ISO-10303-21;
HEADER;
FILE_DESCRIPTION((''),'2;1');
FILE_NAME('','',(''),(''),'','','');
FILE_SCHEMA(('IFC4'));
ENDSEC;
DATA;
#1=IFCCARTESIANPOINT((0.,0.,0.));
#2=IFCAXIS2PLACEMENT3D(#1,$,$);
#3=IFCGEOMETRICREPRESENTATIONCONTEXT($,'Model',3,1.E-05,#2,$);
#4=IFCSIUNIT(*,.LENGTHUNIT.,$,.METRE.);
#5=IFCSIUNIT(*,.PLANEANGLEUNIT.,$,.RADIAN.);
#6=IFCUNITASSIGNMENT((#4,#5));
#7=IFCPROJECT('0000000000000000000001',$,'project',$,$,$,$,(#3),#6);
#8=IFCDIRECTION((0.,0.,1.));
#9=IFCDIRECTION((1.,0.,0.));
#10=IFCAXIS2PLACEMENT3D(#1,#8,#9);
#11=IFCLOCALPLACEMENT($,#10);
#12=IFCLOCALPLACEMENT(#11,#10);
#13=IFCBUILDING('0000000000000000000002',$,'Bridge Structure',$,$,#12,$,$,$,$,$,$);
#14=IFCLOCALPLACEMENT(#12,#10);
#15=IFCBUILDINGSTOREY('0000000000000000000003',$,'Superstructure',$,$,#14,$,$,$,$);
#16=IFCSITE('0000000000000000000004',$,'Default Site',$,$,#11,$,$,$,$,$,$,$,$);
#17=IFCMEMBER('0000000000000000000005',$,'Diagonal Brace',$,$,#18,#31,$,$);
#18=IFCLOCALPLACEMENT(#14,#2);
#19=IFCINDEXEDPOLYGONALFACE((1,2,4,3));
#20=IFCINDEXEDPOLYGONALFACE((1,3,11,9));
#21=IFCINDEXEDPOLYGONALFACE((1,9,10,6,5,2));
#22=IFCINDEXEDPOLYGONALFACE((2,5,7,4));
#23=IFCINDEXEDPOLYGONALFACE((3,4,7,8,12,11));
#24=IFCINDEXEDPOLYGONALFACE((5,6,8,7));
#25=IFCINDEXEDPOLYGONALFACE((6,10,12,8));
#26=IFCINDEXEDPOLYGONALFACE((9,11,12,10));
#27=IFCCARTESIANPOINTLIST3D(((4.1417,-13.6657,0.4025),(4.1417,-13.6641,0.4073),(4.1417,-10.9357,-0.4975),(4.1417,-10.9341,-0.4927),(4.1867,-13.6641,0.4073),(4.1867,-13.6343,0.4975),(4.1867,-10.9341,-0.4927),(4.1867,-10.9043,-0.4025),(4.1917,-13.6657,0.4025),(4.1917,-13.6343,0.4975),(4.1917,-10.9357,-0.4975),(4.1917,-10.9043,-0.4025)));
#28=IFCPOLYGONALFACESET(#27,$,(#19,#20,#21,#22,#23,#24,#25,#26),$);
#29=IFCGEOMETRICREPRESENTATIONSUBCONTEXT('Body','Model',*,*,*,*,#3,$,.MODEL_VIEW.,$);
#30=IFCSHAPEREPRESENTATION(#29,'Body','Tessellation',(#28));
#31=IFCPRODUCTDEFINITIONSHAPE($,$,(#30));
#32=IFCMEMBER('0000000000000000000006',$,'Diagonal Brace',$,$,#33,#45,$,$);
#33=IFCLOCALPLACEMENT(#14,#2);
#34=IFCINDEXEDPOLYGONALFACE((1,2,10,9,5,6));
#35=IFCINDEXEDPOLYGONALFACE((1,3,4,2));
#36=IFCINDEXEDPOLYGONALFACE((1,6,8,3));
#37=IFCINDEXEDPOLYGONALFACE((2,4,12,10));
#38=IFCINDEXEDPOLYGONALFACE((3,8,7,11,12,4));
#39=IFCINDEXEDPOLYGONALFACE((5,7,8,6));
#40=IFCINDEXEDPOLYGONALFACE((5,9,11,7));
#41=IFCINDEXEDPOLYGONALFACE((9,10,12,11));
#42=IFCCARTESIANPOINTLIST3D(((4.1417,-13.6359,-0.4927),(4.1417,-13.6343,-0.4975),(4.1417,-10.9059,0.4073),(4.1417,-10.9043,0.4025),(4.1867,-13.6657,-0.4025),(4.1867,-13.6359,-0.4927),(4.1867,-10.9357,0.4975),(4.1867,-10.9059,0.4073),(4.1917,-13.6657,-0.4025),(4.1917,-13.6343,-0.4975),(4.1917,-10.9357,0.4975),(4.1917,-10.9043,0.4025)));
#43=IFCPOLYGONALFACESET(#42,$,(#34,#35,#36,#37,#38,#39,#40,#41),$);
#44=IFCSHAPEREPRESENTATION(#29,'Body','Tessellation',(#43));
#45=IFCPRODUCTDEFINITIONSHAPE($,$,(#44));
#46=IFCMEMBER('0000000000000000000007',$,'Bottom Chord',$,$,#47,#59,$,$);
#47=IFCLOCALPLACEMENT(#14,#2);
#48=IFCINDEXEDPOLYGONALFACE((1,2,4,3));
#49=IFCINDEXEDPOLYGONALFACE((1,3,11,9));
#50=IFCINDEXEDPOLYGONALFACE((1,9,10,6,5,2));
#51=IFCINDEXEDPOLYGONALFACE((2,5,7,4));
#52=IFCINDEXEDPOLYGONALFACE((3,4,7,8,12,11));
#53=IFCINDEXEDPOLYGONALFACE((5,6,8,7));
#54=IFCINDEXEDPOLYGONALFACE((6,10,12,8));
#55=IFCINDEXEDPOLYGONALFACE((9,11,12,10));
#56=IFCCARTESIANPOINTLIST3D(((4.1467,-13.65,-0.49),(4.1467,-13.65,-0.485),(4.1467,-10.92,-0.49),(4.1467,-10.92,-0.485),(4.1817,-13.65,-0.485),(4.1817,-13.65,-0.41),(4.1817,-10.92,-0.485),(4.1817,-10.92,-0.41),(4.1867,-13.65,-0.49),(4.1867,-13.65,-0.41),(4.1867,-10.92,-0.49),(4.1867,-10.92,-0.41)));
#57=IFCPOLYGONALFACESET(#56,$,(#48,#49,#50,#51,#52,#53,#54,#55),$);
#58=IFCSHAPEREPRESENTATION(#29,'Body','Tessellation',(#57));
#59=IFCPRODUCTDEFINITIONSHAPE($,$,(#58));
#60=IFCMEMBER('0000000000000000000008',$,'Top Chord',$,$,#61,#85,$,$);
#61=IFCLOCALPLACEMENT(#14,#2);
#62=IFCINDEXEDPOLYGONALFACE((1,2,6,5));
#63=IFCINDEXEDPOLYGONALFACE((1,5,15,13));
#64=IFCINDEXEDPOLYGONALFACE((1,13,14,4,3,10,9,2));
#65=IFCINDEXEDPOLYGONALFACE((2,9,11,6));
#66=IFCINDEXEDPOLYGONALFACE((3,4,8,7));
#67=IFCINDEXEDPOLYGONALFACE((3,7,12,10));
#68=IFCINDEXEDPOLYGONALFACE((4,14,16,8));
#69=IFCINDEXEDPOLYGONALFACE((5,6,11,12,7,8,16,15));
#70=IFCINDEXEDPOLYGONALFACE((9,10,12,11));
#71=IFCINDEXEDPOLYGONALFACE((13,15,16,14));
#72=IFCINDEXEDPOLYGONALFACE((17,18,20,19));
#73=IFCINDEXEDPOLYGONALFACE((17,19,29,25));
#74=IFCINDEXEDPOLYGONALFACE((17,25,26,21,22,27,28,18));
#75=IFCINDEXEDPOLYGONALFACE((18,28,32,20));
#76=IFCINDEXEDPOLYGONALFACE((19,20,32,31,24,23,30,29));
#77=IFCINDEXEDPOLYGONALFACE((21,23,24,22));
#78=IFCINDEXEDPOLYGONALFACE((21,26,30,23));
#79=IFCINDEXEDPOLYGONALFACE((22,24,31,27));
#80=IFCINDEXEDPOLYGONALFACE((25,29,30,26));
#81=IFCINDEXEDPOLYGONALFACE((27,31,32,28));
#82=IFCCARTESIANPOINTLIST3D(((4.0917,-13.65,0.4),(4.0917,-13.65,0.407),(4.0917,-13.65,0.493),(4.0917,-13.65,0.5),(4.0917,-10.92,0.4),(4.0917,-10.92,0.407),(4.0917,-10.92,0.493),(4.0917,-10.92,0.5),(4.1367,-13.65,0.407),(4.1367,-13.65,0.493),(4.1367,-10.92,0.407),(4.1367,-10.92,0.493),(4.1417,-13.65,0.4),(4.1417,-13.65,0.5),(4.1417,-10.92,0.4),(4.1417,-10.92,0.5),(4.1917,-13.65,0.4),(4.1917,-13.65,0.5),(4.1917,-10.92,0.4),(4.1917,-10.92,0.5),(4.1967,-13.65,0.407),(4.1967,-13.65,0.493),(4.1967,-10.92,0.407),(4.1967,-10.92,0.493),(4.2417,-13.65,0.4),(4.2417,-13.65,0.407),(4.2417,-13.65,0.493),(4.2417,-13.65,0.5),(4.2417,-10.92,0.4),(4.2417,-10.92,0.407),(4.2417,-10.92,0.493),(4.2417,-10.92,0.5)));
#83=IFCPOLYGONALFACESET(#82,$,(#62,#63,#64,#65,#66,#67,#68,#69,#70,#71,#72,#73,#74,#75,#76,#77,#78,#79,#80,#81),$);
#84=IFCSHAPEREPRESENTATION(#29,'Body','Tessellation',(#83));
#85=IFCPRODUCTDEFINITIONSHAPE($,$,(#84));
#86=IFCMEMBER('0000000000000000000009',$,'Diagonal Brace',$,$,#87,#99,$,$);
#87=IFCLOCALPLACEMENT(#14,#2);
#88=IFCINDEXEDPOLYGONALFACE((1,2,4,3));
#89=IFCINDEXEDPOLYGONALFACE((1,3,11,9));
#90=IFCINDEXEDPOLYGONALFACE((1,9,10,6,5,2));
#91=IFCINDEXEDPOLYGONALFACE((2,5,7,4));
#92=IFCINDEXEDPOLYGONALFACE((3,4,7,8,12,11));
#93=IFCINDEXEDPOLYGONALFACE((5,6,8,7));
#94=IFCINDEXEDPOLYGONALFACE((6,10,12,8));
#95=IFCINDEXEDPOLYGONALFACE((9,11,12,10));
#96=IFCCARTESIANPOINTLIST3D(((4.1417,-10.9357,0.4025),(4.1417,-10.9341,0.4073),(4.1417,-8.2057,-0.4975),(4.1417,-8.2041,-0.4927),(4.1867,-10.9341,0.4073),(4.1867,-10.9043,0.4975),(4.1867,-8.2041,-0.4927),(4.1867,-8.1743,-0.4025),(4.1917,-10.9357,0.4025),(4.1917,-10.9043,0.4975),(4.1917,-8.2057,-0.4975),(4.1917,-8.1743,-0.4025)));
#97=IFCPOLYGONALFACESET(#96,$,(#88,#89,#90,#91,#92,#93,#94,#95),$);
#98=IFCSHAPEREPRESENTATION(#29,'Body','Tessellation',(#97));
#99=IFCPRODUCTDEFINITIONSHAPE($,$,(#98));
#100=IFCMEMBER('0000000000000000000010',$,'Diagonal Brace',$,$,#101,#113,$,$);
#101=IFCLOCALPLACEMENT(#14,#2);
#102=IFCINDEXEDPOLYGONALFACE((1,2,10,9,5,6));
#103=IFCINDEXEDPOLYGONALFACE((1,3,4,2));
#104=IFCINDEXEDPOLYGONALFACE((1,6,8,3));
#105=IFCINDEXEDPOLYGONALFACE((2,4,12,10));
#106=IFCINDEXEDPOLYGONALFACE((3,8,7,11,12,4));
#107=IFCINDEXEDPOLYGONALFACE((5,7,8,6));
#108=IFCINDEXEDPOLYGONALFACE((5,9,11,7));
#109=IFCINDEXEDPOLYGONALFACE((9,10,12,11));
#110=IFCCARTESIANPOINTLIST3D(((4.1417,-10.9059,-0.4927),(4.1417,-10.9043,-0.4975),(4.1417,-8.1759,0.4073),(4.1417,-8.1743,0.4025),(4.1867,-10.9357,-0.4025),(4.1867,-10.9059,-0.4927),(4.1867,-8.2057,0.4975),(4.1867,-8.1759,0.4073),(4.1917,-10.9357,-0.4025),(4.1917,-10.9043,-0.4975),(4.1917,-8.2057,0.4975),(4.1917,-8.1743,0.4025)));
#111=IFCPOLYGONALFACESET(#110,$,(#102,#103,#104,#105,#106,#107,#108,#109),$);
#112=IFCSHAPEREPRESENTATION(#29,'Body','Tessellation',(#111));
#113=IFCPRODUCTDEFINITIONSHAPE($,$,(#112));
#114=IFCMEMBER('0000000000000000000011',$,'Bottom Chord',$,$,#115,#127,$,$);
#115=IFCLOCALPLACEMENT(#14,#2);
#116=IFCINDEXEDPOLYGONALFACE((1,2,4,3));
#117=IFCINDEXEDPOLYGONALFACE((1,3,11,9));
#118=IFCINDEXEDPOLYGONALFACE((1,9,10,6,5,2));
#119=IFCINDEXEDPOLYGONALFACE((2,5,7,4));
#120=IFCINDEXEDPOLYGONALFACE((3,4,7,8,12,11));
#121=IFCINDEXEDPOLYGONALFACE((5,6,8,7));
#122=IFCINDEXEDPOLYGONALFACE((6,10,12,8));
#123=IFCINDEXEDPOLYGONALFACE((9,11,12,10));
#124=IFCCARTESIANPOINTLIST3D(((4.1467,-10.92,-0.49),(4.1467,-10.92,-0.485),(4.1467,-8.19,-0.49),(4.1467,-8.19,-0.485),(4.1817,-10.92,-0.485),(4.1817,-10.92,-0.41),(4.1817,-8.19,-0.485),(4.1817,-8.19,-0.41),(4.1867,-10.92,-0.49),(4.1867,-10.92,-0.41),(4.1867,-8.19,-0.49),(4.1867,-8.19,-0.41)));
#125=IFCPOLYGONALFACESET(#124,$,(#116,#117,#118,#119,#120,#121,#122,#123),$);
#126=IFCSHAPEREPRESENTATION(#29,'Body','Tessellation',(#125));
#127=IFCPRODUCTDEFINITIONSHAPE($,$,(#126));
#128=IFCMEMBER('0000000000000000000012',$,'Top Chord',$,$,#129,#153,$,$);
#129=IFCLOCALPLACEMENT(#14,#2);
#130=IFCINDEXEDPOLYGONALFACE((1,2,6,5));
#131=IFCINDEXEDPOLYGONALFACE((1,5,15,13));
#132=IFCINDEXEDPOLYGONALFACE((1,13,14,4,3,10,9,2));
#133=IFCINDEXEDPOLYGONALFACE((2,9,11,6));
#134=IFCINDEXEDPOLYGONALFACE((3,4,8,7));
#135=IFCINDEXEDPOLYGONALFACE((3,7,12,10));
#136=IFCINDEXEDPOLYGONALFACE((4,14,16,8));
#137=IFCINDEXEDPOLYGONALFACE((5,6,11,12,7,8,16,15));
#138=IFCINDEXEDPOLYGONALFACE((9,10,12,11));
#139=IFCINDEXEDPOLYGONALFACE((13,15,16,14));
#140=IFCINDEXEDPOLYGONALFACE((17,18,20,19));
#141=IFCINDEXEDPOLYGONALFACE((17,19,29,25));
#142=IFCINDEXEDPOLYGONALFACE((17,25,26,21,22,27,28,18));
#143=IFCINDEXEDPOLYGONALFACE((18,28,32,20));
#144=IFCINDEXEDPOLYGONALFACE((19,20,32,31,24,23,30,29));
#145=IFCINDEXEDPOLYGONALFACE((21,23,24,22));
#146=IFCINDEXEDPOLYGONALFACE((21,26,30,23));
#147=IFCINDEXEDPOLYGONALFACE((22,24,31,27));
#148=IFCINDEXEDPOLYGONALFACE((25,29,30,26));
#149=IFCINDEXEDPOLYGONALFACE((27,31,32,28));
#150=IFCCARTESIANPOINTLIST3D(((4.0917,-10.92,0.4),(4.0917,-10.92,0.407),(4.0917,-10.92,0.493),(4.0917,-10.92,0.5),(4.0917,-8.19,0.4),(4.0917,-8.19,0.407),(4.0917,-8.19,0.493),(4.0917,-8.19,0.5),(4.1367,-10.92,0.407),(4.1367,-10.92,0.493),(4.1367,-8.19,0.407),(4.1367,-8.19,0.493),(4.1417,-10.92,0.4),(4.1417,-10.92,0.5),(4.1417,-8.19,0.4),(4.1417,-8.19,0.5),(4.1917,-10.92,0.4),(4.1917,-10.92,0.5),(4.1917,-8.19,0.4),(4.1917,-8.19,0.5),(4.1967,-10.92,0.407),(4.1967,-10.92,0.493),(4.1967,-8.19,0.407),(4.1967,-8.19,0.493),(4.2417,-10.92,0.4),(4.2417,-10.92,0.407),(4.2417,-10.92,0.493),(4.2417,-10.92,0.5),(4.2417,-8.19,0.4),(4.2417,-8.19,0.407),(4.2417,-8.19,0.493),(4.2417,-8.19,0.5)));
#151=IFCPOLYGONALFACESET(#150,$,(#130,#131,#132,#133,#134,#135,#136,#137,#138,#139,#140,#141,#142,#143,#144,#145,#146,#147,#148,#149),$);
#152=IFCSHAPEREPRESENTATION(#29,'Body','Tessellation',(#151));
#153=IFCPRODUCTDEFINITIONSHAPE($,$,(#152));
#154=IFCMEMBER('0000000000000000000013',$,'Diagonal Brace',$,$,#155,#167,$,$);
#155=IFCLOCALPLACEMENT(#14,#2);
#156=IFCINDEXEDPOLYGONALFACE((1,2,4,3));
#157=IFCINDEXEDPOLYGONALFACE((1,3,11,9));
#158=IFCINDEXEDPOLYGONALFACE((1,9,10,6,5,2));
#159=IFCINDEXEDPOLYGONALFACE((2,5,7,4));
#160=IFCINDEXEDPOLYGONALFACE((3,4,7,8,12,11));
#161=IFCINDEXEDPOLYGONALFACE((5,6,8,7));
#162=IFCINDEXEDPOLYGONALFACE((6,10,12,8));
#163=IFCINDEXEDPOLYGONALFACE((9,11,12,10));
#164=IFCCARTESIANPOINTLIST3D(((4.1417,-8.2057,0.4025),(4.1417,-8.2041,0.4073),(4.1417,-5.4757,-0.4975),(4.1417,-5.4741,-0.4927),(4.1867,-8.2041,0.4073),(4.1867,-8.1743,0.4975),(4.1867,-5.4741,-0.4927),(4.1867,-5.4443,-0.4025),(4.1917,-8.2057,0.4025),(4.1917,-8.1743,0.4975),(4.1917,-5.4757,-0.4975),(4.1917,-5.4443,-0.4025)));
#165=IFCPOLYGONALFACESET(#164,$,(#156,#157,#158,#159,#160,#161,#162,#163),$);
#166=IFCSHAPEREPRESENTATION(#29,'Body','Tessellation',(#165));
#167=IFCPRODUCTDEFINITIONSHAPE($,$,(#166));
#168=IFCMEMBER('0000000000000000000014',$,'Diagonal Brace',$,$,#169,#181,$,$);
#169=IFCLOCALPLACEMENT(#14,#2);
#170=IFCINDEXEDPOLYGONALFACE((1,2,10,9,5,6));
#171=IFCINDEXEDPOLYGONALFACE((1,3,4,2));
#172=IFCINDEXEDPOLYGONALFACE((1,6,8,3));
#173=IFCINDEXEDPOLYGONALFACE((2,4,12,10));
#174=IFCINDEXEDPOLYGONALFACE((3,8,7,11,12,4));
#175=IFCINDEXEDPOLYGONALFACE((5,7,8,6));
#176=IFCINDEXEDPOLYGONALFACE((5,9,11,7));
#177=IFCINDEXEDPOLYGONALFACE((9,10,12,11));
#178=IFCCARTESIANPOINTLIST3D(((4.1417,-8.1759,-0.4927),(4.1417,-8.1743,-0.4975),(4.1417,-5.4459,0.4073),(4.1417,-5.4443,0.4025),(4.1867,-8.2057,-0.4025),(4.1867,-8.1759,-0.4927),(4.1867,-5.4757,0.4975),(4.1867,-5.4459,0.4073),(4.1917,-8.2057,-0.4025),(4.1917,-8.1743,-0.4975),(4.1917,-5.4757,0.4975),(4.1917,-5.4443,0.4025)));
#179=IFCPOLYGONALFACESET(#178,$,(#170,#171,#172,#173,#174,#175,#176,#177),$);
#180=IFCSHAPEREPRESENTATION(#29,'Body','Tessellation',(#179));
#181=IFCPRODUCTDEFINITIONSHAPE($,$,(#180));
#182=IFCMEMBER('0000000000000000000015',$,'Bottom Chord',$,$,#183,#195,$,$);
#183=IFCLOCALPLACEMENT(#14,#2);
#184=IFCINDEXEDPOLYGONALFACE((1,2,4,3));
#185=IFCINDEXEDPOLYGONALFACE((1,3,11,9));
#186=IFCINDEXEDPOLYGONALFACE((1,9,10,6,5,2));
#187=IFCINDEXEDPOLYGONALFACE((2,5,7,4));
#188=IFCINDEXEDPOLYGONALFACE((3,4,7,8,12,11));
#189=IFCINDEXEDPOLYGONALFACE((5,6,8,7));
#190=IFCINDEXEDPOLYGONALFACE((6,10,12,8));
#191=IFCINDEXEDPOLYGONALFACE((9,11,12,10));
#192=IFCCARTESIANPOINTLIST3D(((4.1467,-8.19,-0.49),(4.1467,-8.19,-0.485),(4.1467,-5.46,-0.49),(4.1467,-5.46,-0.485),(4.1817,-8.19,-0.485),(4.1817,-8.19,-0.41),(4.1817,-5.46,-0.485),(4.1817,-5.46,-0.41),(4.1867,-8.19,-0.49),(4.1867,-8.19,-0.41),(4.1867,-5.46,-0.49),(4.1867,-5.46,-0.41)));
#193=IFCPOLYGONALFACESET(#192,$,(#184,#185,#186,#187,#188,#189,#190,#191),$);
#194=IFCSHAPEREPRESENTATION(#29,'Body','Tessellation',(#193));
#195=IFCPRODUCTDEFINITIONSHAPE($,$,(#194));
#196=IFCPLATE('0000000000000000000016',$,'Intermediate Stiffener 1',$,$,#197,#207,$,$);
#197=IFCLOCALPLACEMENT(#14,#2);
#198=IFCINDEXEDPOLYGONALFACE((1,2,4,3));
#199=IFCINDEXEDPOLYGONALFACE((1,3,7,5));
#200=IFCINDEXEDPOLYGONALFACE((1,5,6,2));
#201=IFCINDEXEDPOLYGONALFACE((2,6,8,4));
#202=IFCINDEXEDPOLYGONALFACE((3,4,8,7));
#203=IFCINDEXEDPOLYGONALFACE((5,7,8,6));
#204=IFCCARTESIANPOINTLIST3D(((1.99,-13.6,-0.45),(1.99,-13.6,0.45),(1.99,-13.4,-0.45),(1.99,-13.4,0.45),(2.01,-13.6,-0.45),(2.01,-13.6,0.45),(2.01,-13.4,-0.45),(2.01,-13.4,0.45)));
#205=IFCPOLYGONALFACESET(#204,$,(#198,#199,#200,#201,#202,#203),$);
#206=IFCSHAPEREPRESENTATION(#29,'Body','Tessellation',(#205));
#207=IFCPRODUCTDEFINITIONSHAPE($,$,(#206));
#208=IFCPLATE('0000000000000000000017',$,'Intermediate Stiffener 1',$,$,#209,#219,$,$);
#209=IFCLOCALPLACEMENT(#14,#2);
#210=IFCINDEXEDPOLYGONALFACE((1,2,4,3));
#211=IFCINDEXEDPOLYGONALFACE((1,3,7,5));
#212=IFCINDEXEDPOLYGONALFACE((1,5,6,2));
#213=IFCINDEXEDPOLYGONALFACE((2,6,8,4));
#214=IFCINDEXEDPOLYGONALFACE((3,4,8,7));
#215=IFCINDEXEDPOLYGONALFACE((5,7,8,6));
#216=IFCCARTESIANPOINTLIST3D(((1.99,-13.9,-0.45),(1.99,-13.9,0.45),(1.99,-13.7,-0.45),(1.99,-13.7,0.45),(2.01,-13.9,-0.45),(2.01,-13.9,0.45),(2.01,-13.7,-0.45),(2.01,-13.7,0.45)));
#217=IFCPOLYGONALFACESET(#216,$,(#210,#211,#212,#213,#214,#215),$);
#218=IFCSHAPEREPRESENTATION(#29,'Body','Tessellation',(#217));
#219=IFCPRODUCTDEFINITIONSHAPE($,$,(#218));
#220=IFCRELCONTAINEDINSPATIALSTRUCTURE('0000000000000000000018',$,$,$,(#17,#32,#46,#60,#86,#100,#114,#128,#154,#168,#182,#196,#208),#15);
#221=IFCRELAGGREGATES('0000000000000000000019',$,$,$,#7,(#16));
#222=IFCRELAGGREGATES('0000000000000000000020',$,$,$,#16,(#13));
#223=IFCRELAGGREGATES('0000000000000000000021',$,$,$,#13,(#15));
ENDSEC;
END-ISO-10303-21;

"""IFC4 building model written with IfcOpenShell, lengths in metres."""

from ifc_helpers import new_model, si_unit, frame, origin, origin_with_axes, origin_2d_with_axis, place, context, subcontext, project, spatial, polyline, rectangle, l_section, outline, composite_profile, extrude, element, save


model = new_model("IFC4")

# Units and contexts
model_context = context("Model", 3, precision=1e-05, world=origin())
body_context = subcontext(model_context, "Body", "Model", "MODEL_VIEW")
ifc_project = project(units=[si_unit("LENGTHUNIT", "METRE"), si_unit("PLANEANGLEUNIT", "RADIAN")], contexts=[model_context])

# Site, building, storey
site_placement = place(None, origin_with_axes())
site = spatial("IfcSite", under=ifc_project, at=site_placement, Name="Default Site")
building_placement = place(site_placement, origin_with_axes())
building = spatial("IfcBuilding", under=site, at=building_placement, Name="Bridge Structure")
storey_placement = place(building_placement, origin_with_axes())
storey = spatial("IfcBuildingStorey", under=building, at=storey_placement, Name="Superstructure")

# Members
for number, where, z_axis, x_axis, name in (
    (1, (4.1667, -13.65, 0.45), (0.0, 0.949722, -0.313095), (-1.0, 0.0, 0.0), "Diagonal Brace"),
    (2, (4.1667, -13.65, -0.45), (0.0, 0.949722, 0.313095), (-1.0, 0.0, 0.0), "Diagonal Brace"),
):
    element("IfcMember", number, at=place(storey_placement, frame(where, z_axis=z_axis, x_axis=x_axis)), inside=storey, Name=name, context=body_context, shape_type="SweptSolid", body=[
        extrude(l_section(Depth=0.1, Width=0.05, Thickness=0.005, at=origin_2d_with_axis()), origin_with_axes(), (0.0, 0.0, 1.0), 2.8745),
    ])
member_1_placement = place(storey_placement, frame((4.1667, -13.65, -0.45), z_axis=(0.0, 1.0, 0.0), x_axis=(-1.0, 0.0, 0.0)))
element("IfcMember", 3, at=member_1_placement, inside=storey, Name="Bottom Chord", context=body_context, shape_type="SweptSolid", body=[
    extrude(l_section(Depth=0.08, Width=0.04, Thickness=0.005, at=origin_2d_with_axis()), origin_with_axes(), (0.0, 0.0, 1.0), 2.73),
])
member_2_placement = place(storey_placement, frame((4.1667, -13.65, 0.45), z_axis=(0.0, 1.0, 0.0), x_axis=(-1.0, 0.0, 0.0)))
element("IfcMember", 4, at=member_2_placement, inside=storey, Name="Top Chord", context=body_context, shape_type="SweptSolid", body=[
    extrude(composite_profile([outline(polyline([(-0.025, -0.05), (-0.025, 0.05), (-0.075, 0.05), (-0.075, 0.043), (-0.03, 0.043), (-0.03, -0.043), (-0.075, -0.043), (-0.075, -0.05), (-0.025, -0.05)])), outline(polyline([(0.025, -0.05), (0.075, -0.05), (0.075, -0.043), (0.03, -0.043), (0.03, 0.043), (0.075, 0.043), (0.075, 0.05), (0.025, 0.05), (0.025, -0.05)]))]), origin_with_axes(), (0.0, 0.0, 1.0), 2.73),
])
for number, where, z_axis, x_axis, name in (
    (5, (4.1667, -10.92, 0.45), (0.0, 0.949722, -0.313095), (-1.0, 0.0, 0.0), "Diagonal Brace"),
    (6, (4.1667, -10.92, -0.45), (0.0, 0.949722, 0.313095), (-1.0, 0.0, 0.0), "Diagonal Brace"),
):
    element("IfcMember", number, at=place(storey_placement, frame(where, z_axis=z_axis, x_axis=x_axis)), inside=storey, Name=name, context=body_context, shape_type="SweptSolid", body=[
        extrude(l_section(Depth=0.1, Width=0.05, Thickness=0.005, at=origin_2d_with_axis()), origin_with_axes(), (0.0, 0.0, 1.0), 2.8745),
    ])
member_3_placement = place(storey_placement, frame((4.1667, -10.92, -0.45), z_axis=(0.0, 1.0, 0.0), x_axis=(-1.0, 0.0, 0.0)))
element("IfcMember", 7, at=member_3_placement, inside=storey, Name="Bottom Chord", context=body_context, shape_type="SweptSolid", body=[
    extrude(l_section(Depth=0.08, Width=0.04, Thickness=0.005, at=origin_2d_with_axis()), origin_with_axes(), (0.0, 0.0, 1.0), 2.73),
])
member_4_placement = place(storey_placement, frame((4.1667, -10.92, 0.45), z_axis=(0.0, 1.0, 0.0), x_axis=(-1.0, 0.0, 0.0)))
element("IfcMember", 8, at=member_4_placement, inside=storey, Name="Top Chord", context=body_context, shape_type="SweptSolid", body=[
    extrude(composite_profile([outline(polyline([(-0.025, -0.05), (-0.025, 0.05), (-0.075, 0.05), (-0.075, 0.043), (-0.03, 0.043), (-0.03, -0.043), (-0.075, -0.043), (-0.075, -0.05), (-0.025, -0.05)])), outline(polyline([(0.025, -0.05), (0.075, -0.05), (0.075, -0.043), (0.03, -0.043), (0.03, 0.043), (0.075, 0.043), (0.075, 0.05), (0.025, 0.05), (0.025, -0.05)]))]), origin_with_axes(), (0.0, 0.0, 1.0), 2.73),
])
for number, where, z_axis, x_axis, name in (
    (9, (4.1667, -8.19, 0.45), (0.0, 0.949722, -0.313095), (-1.0, 0.0, 0.0), "Diagonal Brace"),
    (10, (4.1667, -8.19, -0.45), (0.0, 0.949722, 0.313095), (-1.0, 0.0, 0.0), "Diagonal Brace"),
):
    element("IfcMember", number, at=place(storey_placement, frame(where, z_axis=z_axis, x_axis=x_axis)), inside=storey, Name=name, context=body_context, shape_type="SweptSolid", body=[
        extrude(l_section(Depth=0.1, Width=0.05, Thickness=0.005, at=origin_2d_with_axis()), origin_with_axes(), (0.0, 0.0, 1.0), 2.8745),
    ])
member_5_placement = place(storey_placement, frame((4.1667, -8.19, -0.45), z_axis=(0.0, 1.0, 0.0), x_axis=(-1.0, 0.0, 0.0)))
element("IfcMember", 11, at=member_5_placement, inside=storey, Name="Bottom Chord", context=body_context, shape_type="SweptSolid", body=[
    extrude(l_section(Depth=0.08, Width=0.04, Thickness=0.005, at=origin_2d_with_axis()), origin_with_axes(), (0.0, 0.0, 1.0), 2.73),
])

# Plates
for number, where, z_axis, x_axis, name in (
    (12, (2.0, -13.5, -0.45), (0.0, 0.0, 1.0), (1.0, 0.0, 0.0), "Intermediate Stiffener 1"),
    (13, (2.0, -13.8, -0.45), (0.0, 0.0, 1.0), (1.0, 0.0, 0.0), "Intermediate Stiffener 1"),
):
    element("IfcPlate", number, at=place(storey_placement, frame(where, z_axis=z_axis, x_axis=x_axis)), inside=storey, Name=name, context=body_context, shape_type="SweptSolid", body=[
        extrude(rectangle(XDim=0.02, YDim=0.2, at=origin_2d_with_axis()), origin_with_axes(), (0.0, 0.0, 1.0), 0.9),
    ])

save(model, "model.ifc")
